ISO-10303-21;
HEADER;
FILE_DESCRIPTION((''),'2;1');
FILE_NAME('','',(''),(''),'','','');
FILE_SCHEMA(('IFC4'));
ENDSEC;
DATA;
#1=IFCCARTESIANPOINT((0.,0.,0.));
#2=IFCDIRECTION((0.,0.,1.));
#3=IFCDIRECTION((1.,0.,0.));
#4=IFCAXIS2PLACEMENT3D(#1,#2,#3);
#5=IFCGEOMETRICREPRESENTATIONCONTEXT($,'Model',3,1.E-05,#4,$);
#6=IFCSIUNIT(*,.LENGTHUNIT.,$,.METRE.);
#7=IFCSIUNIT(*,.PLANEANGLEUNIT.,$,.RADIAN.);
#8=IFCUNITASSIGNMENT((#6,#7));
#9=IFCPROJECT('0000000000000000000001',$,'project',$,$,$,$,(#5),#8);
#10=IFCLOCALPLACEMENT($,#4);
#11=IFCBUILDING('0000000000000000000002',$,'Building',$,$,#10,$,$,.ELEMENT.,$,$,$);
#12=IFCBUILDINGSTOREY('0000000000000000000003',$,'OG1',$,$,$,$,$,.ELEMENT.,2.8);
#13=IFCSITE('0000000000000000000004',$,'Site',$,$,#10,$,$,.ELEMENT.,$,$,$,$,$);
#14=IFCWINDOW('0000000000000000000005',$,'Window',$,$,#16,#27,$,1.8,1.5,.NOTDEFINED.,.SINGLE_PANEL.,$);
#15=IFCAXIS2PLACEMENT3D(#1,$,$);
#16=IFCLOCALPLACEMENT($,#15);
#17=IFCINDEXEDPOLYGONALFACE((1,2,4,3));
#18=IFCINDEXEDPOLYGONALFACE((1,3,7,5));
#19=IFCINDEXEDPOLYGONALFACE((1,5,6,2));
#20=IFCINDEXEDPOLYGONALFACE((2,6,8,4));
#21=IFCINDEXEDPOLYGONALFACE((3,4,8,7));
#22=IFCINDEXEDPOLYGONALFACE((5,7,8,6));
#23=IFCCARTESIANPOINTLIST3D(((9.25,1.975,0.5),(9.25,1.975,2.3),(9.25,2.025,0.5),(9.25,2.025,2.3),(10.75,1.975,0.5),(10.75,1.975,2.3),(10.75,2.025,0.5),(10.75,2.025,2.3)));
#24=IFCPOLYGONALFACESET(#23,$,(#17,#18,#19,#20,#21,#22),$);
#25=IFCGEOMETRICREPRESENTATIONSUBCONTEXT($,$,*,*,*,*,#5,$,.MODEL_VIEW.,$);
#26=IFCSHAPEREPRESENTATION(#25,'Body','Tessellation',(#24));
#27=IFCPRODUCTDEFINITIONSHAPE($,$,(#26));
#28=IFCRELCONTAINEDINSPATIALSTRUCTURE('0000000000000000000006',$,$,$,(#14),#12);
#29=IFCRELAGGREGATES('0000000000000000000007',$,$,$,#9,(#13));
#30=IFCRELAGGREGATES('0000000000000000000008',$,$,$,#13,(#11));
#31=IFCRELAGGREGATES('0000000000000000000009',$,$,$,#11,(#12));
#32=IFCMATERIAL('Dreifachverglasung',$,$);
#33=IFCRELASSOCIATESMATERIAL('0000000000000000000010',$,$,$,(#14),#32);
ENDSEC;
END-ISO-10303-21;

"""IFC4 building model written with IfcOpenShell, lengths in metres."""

from ifc_helpers import new_model, si_unit, frame, origin, origin_with_axes, origin_2d, place, context, subcontext, project, spatial, rectangle, extrude, material, element, save


model = new_model("IFC4")

# Units and contexts
model_context = context("Model", 3, precision=1e-05, world=origin_with_axes())
sub_context = subcontext(model_context, None, None, "MODEL_VIEW")
ifc_project = project(units=[si_unit("LENGTHUNIT", "METRE"), si_unit("PLANEANGLEUNIT", "RADIAN")], contexts=[model_context])

# Site, building, storey
placement_1 = place(None, origin_with_axes())
site = spatial("IfcSite", under=ifc_project, at=placement_1, Name="Site", CompositionType="ELEMENT")
building = spatial("IfcBuilding", under=site, at=placement_1, Name="Building", CompositionType="ELEMENT")
storey = spatial("IfcBuildingStorey", under=building, Name="OG1", CompositionType="ELEMENT", Elevation=2.8)

# Window
ifc_material = material(Name="Dreifachverglasung")
placement_2 = place(None, origin_with_axes())
window_placement = place(placement_2, frame((10.0, 2.0, 0.5)))
element("IfcWindow", 1, at=window_placement, inside=storey, material=ifc_material, Name="Window", OverallHeight=1.8, OverallWidth=1.5, PartitioningType="SINGLE_PANEL", PredefinedType="NOTDEFINED", context=sub_context, shape_type="SweptSolid", body=[
    extrude(rectangle(XDim=1.5, YDim=0.05, at=origin_2d()), origin(), (0.0, 0.0, 1.0), 1.8),
])

save(model, "model.ifc")
